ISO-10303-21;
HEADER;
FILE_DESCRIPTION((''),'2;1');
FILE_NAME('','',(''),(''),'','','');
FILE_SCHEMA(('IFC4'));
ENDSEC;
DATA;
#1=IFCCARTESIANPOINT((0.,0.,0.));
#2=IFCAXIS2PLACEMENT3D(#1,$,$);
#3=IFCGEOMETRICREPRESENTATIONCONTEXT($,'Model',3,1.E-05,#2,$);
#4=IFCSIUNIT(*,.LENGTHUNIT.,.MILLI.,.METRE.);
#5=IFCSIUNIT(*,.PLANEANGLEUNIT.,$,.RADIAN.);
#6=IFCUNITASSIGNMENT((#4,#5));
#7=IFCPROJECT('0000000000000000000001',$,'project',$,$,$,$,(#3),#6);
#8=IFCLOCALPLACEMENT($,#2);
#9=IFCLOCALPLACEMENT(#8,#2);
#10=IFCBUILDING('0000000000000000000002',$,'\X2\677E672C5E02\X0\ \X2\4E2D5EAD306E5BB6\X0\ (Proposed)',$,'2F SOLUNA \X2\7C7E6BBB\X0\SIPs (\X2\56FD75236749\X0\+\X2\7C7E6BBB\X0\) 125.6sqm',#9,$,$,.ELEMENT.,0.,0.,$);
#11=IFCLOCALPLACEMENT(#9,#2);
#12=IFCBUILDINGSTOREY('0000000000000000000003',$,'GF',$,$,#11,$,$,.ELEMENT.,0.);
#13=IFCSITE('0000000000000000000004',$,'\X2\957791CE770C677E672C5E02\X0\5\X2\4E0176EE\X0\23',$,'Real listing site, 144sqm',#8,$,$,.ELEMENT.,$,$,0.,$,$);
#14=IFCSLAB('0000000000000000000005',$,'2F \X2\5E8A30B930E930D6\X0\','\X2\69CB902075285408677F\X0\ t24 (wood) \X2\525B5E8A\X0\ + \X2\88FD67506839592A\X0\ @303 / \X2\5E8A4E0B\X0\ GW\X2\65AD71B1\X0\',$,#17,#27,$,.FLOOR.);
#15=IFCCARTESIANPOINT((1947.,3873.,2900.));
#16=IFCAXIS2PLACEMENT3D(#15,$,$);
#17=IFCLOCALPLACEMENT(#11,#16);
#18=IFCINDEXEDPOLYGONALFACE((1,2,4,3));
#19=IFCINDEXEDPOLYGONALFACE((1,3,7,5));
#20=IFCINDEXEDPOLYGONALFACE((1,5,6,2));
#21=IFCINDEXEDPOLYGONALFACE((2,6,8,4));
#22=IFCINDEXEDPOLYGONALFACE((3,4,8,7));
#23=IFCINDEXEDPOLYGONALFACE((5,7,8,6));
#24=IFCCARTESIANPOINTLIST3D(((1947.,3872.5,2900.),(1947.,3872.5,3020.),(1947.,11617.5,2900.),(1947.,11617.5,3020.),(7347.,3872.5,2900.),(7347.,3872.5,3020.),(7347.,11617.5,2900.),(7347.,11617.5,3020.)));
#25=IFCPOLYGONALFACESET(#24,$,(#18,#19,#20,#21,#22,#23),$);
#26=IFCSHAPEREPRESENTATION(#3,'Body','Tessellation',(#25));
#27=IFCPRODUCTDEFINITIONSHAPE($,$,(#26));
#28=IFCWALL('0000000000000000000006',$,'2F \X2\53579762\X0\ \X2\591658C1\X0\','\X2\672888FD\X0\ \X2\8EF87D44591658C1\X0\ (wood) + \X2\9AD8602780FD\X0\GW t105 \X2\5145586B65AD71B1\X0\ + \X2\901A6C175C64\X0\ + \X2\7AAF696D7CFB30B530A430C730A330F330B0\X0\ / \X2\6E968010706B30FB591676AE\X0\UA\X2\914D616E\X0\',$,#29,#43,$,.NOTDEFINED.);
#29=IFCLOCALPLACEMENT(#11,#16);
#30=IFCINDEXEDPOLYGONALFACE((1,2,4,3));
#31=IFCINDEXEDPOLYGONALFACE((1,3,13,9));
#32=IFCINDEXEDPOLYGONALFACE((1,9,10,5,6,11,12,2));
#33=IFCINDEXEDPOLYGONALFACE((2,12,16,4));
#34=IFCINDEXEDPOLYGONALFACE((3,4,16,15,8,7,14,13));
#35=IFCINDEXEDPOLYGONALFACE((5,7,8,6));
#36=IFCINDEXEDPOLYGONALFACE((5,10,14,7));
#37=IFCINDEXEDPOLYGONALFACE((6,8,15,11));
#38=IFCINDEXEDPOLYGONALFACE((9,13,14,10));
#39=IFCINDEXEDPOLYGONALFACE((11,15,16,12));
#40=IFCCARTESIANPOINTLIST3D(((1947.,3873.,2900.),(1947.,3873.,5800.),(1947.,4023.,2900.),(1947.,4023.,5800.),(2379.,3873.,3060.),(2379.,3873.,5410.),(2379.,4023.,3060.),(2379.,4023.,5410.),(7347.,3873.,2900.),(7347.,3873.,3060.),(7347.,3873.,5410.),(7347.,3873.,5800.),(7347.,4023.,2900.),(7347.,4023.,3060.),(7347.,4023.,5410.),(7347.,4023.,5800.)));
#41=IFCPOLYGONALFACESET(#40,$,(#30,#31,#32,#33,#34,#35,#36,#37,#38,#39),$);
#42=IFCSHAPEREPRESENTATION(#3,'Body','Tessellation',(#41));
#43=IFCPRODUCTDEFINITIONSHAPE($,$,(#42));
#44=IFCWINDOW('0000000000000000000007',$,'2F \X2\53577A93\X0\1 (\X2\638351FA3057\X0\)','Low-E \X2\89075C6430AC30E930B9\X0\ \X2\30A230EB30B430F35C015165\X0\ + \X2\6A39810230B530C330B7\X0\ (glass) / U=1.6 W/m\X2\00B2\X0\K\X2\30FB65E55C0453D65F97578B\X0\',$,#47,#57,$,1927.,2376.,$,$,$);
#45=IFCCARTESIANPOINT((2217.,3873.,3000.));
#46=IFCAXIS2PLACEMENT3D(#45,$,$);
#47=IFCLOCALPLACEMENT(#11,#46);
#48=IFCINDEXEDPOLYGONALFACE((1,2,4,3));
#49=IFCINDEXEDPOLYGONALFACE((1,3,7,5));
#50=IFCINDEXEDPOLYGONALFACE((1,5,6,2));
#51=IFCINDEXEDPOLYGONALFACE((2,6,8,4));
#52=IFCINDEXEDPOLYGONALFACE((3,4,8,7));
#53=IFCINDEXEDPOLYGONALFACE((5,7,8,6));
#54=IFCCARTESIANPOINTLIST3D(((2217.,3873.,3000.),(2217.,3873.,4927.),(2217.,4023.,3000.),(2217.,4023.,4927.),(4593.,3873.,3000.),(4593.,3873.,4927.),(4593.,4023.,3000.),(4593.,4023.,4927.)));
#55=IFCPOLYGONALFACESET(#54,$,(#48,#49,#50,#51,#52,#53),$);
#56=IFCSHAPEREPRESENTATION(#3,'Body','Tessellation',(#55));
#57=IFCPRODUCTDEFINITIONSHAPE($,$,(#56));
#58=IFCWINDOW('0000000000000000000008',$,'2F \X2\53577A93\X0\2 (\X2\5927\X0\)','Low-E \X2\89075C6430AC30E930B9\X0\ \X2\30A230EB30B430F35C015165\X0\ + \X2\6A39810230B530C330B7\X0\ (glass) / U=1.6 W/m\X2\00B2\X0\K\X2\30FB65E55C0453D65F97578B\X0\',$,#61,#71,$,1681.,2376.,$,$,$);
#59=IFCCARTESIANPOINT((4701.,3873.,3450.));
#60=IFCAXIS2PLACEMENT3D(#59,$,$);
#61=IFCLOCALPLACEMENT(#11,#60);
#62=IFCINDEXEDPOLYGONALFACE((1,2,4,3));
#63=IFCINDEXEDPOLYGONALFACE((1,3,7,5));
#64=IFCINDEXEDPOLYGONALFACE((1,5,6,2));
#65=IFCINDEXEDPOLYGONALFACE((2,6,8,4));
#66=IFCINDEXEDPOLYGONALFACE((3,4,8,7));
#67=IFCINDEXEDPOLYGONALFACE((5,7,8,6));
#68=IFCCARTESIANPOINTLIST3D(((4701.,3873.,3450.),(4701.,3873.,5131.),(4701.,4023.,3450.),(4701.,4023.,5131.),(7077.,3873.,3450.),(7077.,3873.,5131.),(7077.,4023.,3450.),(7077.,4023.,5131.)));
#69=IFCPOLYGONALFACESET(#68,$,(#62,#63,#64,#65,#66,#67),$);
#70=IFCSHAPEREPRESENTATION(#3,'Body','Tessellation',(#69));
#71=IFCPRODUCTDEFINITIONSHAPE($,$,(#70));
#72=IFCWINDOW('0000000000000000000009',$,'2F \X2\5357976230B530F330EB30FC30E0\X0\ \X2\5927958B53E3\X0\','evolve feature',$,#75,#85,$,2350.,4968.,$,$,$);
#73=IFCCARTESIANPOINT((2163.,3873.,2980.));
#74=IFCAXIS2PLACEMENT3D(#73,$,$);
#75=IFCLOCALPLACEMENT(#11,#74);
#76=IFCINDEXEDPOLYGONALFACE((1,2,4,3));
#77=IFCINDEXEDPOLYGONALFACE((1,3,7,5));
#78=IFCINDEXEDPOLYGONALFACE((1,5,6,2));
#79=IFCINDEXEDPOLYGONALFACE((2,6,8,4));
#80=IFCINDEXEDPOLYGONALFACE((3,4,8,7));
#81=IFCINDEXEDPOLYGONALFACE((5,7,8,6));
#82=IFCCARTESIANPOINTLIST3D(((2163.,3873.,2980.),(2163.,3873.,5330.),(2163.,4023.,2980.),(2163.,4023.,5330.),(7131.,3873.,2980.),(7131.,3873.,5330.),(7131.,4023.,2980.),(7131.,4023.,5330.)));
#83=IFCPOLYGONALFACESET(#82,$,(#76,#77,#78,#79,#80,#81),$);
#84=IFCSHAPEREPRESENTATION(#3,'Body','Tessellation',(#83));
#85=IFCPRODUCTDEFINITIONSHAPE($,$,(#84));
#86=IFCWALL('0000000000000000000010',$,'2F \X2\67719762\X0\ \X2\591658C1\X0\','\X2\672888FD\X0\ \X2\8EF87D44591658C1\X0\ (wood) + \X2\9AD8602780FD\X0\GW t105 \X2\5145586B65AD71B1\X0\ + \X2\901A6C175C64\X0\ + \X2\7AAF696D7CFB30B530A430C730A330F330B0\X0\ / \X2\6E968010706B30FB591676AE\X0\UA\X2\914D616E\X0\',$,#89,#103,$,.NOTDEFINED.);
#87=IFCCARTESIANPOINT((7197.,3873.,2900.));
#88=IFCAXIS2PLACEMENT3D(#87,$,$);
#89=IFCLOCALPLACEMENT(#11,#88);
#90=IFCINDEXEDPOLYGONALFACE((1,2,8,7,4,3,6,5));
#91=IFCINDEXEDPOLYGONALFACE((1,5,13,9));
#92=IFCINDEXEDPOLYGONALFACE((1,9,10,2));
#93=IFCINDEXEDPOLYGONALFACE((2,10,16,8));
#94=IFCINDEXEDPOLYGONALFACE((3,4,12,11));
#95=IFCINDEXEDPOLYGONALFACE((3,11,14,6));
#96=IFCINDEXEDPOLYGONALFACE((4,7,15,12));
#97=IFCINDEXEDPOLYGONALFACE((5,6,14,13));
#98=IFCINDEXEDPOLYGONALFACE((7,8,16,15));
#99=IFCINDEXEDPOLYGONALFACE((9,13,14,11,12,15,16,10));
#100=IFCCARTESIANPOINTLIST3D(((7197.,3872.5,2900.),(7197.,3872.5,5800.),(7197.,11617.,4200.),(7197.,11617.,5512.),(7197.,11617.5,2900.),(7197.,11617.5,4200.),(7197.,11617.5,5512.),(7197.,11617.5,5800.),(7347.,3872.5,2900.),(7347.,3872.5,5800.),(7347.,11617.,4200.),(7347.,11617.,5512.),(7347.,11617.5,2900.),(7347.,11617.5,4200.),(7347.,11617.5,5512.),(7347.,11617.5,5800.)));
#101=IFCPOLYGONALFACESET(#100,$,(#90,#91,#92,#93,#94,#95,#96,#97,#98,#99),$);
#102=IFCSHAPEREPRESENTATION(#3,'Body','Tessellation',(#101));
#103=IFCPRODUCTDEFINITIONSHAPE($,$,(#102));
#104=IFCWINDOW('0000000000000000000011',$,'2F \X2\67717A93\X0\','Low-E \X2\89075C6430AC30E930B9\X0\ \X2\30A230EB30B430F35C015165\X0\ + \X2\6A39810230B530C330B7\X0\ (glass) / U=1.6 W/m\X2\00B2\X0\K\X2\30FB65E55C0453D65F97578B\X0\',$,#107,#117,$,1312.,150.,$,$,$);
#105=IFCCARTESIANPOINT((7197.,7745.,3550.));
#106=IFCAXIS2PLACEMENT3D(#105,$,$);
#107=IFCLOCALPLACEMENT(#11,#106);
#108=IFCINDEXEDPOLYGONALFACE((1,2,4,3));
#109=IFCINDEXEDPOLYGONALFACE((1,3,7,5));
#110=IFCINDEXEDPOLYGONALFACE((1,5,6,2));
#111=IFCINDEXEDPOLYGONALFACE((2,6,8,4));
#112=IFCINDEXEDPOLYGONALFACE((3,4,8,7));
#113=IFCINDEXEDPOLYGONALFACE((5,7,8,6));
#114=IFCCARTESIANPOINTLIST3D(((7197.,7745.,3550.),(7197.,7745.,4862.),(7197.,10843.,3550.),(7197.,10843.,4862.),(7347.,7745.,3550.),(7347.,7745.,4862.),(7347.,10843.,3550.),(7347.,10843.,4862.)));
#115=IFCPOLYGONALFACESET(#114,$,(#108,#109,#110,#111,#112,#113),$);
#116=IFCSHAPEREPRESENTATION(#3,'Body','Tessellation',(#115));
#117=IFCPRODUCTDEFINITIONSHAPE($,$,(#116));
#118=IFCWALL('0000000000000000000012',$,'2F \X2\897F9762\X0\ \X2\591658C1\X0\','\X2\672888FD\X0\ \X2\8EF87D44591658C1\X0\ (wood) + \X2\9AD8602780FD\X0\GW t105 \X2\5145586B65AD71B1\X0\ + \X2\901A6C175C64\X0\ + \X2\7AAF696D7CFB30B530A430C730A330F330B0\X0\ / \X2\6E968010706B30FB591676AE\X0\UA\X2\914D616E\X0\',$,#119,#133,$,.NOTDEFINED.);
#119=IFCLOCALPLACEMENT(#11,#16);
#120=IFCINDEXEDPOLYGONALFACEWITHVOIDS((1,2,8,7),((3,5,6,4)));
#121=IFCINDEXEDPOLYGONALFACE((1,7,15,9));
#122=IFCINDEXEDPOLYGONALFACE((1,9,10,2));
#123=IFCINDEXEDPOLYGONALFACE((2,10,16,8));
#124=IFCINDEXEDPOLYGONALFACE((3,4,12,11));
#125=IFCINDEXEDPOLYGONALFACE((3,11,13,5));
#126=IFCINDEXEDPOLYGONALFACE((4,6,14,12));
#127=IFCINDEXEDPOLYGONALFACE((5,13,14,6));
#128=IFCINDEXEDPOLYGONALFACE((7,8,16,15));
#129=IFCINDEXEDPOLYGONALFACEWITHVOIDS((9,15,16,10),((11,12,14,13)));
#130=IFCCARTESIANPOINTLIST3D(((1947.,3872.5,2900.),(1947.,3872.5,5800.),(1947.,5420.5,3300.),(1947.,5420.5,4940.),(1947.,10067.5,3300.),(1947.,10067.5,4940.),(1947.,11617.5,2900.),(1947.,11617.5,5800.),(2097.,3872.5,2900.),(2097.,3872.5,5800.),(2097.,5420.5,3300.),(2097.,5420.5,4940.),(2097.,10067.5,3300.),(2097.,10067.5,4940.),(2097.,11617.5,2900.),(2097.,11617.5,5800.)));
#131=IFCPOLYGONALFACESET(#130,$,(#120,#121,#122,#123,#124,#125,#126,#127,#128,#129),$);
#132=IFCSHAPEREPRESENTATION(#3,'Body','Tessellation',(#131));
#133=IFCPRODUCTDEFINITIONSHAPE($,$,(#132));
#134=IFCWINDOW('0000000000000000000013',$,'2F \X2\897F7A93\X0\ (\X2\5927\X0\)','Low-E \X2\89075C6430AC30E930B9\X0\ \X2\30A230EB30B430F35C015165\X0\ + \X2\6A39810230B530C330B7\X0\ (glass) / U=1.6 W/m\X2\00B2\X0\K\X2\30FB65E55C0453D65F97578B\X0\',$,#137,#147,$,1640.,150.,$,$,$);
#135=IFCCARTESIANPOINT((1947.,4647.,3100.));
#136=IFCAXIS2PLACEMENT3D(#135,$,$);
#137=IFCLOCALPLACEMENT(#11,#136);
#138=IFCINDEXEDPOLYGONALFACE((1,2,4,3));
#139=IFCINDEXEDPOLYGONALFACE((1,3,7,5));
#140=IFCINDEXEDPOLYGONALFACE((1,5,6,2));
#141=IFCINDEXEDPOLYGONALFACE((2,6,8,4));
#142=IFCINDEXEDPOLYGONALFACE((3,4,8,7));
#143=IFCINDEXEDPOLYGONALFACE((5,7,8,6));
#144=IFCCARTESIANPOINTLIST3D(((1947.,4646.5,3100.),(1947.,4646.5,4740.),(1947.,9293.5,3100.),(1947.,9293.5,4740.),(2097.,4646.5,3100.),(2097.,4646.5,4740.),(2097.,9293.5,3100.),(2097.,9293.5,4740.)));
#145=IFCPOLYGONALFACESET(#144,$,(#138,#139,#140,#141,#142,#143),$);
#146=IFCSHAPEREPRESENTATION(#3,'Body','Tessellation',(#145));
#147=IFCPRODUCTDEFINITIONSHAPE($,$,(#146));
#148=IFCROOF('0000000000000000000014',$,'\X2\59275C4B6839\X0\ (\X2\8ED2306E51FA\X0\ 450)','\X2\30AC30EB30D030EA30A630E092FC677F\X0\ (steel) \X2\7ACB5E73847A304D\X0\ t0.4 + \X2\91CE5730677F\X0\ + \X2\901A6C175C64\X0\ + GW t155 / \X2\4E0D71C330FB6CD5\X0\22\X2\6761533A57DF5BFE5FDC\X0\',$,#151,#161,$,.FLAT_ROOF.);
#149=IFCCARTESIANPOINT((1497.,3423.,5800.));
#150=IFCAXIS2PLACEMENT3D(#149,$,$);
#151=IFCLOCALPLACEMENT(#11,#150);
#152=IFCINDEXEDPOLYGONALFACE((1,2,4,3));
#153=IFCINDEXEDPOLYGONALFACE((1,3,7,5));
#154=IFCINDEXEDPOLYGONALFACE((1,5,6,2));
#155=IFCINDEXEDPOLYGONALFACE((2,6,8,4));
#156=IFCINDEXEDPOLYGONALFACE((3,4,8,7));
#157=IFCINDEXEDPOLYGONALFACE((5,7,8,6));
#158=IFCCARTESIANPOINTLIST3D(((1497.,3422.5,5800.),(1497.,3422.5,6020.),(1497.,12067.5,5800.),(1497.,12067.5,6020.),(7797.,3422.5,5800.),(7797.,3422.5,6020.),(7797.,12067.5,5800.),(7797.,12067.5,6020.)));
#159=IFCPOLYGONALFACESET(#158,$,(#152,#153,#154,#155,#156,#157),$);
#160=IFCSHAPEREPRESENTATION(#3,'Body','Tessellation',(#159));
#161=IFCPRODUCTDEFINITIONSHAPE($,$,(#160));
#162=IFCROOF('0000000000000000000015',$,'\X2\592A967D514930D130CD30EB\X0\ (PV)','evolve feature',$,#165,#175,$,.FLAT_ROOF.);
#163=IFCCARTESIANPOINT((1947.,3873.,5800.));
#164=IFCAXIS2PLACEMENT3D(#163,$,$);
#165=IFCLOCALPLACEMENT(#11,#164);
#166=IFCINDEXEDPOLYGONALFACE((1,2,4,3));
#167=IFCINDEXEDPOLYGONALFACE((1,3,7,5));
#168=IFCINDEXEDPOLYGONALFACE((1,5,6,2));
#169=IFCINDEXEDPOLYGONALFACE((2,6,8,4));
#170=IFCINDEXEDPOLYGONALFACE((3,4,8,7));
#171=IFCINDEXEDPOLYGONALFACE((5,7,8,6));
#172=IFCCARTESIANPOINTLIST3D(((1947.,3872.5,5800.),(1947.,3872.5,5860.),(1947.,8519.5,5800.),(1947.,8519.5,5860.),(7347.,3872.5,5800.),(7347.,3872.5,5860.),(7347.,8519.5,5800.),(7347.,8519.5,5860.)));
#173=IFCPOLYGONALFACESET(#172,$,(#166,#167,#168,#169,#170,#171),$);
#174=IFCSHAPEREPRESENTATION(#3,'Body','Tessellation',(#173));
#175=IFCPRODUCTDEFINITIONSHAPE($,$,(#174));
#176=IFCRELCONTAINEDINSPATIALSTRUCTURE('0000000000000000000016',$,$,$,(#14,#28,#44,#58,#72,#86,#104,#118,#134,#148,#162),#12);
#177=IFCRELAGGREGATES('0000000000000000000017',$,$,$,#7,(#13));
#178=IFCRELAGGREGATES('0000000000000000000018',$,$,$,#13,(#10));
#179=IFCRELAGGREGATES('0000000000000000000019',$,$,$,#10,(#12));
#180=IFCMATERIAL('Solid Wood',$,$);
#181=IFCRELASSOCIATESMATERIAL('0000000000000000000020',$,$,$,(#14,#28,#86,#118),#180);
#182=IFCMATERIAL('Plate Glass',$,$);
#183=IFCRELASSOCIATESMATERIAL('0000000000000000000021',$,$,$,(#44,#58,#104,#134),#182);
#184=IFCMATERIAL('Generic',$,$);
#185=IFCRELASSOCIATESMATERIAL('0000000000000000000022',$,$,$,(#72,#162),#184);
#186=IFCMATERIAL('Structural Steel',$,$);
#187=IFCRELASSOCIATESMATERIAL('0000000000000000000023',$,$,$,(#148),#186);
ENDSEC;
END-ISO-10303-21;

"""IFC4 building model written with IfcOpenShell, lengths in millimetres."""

from ifc_helpers import new_model, si_unit, frame, frame_2d, origin, place, context, project, spatial, rectangle, extrude, material, element, fill, save


model = new_model("IFC4")

# Units and contexts
model_context = context("Model", 3, precision=1e-05, world=origin())
ifc_project = project(units=[si_unit("LENGTHUNIT", "METRE", prefix="MILLI"), si_unit("PLANEANGLEUNIT", "RADIAN")], contexts=[model_context])

# Site, building, storey
site_placement = place(None, origin())
site = spatial("IfcSite", under=ifc_project, at=site_placement, Name="長野県松本市5丁目23", ObjectType="Real listing site, 144sqm", CompositionType="ELEMENT", RefElevation=0.0)
building_placement = place(site_placement, origin())
building = spatial("IfcBuilding", under=site, at=building_placement, Name="松本市 中庭の家 (Proposed)", ObjectType="2F SOLUNA 籾殻SIPs (国産杉+籾殻) 125.6sqm", CompositionType="ELEMENT", ElevationOfRefHeight=0.0, ElevationOfTerrain=0.0)
storey_placement = place(building_placement, origin())
storey = spatial("IfcBuildingStorey", under=building, at=storey_placement, Name="GF", CompositionType="ELEMENT", Elevation=0.0)

# Slab
ifc_material_1 = material(Name="Solid Wood")
slab_placement = place(storey_placement, frame((1947.0, 3873.0, 2900.0)))
element("IfcSlab", 1, at=slab_placement, inside=storey, material=ifc_material_1, Name="2F 床スラブ", Description="構造用合板 t24 (wood) 剛床 + 製材根太 @303 / 床下 GW断熱", PredefinedType="FLOOR", context=model_context, shape_type="SweptSolid", body=[
    extrude(rectangle(XDim=5400.0, YDim=7745.0, at=frame_2d((2700.0, 3872.0))), frame((1947.0, 3873.0, 2900.0)), (0.0, 0.0, 1.0), 120.0),
])

# Wall, openings, windows
wall_1_placement = place(storey_placement, frame((1947.0, 3873.0, 2900.0)))
wall_1 = element("IfcWall", 2, at=wall_1_placement, inside=storey, material=ifc_material_1, Name="2F 南面 外壁", Description="木製 軸組外壁 (wood) + 高性能GW t105 充填断熱 + 通気層 + 窯業系サイディング / 準耐火・外皮UA配慮", PredefinedType="NOTDEFINED", context=model_context, shape_type="SweptSolid", body=[
    extrude(rectangle(XDim=5400.0, YDim=150.0, at=frame_2d((2700.0, 75.0))), frame((1947.0, 3873.0, 2900.0)), (0.0, 0.0, 1.0), 2900.0),
])
opening_1_placement = place(storey_placement, frame((2217.0, 3873.0, 3000.0)))
opening_1 = element("IfcOpeningElement", 3, at=opening_1_placement, cuts=wall_1, PredefinedType="NOTDEFINED", context=model_context, shape_type="SweptSolid", body=[
    extrude(rectangle(XDim=2376.0, YDim=150.0, at=frame_2d((1188.0, 75.0))), frame((2217.0, 3873.0, 3000.0)), (0.0, 0.0, 1.0), 1927.0),
])
opening_2_placement = place(storey_placement, frame((4701.0, 3873.0, 3450.0)))
opening_2 = element("IfcOpeningElement", 4, at=opening_2_placement, cuts=wall_1, PredefinedType="NOTDEFINED", context=model_context, shape_type="SweptSolid", body=[
    extrude(rectangle(XDim=2376.0, YDim=150.0, at=frame_2d((1188.0, 75.0))), frame((4701.0, 3873.0, 3450.0)), (0.0, 0.0, 1.0), 1681.0),
])
opening_3_placement = place(storey_placement, frame((2163.0, 3873.0, 2980.0)))
opening_3 = element("IfcOpeningElement", 5, at=opening_3_placement, cuts=wall_1, PredefinedType="NOTDEFINED", context=model_context, shape_type="SweptSolid", body=[
    extrude(rectangle(XDim=4968.0, YDim=150.0, at=frame_2d((2484.0, 75.0))), frame((2163.0, 3873.0, 2980.0)), (0.0, 0.0, 1.0), 2350.0),
])
ifc_material_2 = material(Name="Plate Glass")
window_1_placement = place(storey_placement, frame((2217.0, 3873.0, 3000.0)))
window_1 = element("IfcWindow", 6, at=window_1_placement, inside=storey, material=ifc_material_2, Name="2F 南窓1 (掃出し)", Description="Low-E 複層ガラス アルゴン封入 + 樹脂サッシ (glass) / U=1.6 W/m²K・日射取得型", OverallHeight=1927.0, OverallWidth=2376.0, context=model_context, shape_type="SweptSolid", body=[
    extrude(rectangle(XDim=2376.0, YDim=150.0, at=frame_2d((1188.0, 75.0))), frame((2217.0, 3873.0, 3000.0)), (0.0, 0.0, 1.0), 1927.0),
])
fill(opening_1, window_1)
window_2_placement = place(storey_placement, frame((4701.0, 3873.0, 3450.0)))
window_2 = element("IfcWindow", 7, at=window_2_placement, inside=storey, material=ifc_material_2, Name="2F 南窓2 (大)", Description="Low-E 複層ガラス アルゴン封入 + 樹脂サッシ (glass) / U=1.6 W/m²K・日射取得型", OverallHeight=1681.0, OverallWidth=2376.0, context=model_context, shape_type="SweptSolid", body=[
    extrude(rectangle(XDim=2376.0, YDim=150.0, at=frame_2d((1188.0, 75.0))), frame((4701.0, 3873.0, 3450.0)), (0.0, 0.0, 1.0), 1681.0),
])
fill(opening_2, window_2)
ifc_material_3 = material(Name="Generic")
window_3_placement = place(storey_placement, frame((2163.0, 3873.0, 2980.0)))
window_3 = element("IfcWindow", 8, at=window_3_placement, inside=storey, material=ifc_material_3, Name="2F 南面サンルーム 大開口", Description="evolve feature", OverallHeight=2350.0, OverallWidth=4968.0, context=model_context, shape_type="SweptSolid", body=[
    extrude(rectangle(XDim=4968.0, YDim=150.0, at=frame_2d((2484.0, 75.0))), frame((2163.0, 3873.0, 2980.0)), (0.0, 0.0, 1.0), 2350.0),
])
fill(opening_3, window_3)

# Walls, openings, windows
wall_2_placement = place(storey_placement, frame((7197.0, 3873.0, 2900.0)))
wall_2 = element("IfcWall", 9, at=wall_2_placement, inside=storey, material=ifc_material_1, Name="2F 東面 外壁", Description="木製 軸組外壁 (wood) + 高性能GW t105 充填断熱 + 通気層 + 窯業系サイディング / 準耐火・外皮UA配慮", PredefinedType="NOTDEFINED", context=model_context, shape_type="SweptSolid", body=[
    extrude(rectangle(XDim=150.0, YDim=7745.0, at=frame_2d((75.0, 3872.0))), frame((7197.0, 3873.0, 2900.0)), (0.0, 0.0, 1.0), 2900.0),
])
opening_4_placement = place(storey_placement, frame((7197.0, 7745.0, 3550.0)))
opening_4 = element("IfcOpeningElement", 10, at=opening_4_placement, cuts=wall_2, PredefinedType="NOTDEFINED", context=model_context, shape_type="SweptSolid", body=[
    extrude(rectangle(XDim=150.0, YDim=3098.0, at=frame_2d((75.0, 1549.0))), frame((7197.0, 7745.0, 3550.0)), (0.0, 0.0, 1.0), 1312.0),
])
window_4_placement = place(storey_placement, frame((7197.0, 7745.0, 3550.0)))
window_4 = element("IfcWindow", 11, at=window_4_placement, inside=storey, material=ifc_material_2, Name="2F 東窓", Description="Low-E 複層ガラス アルゴン封入 + 樹脂サッシ (glass) / U=1.6 W/m²K・日射取得型", OverallHeight=1312.0, OverallWidth=150.0, context=model_context, shape_type="SweptSolid", body=[
    extrude(rectangle(XDim=150.0, YDim=3098.0, at=frame_2d((75.0, 1549.0))), frame((7197.0, 7745.0, 3550.0)), (0.0, 0.0, 1.0), 1312.0),
])
fill(opening_4, window_4)
wall_3_placement = place(storey_placement, frame((1947.0, 3873.0, 2900.0)))
wall_3 = element("IfcWall", 12, at=wall_3_placement, inside=storey, material=ifc_material_1, Name="2F 西面 外壁", Description="木製 軸組外壁 (wood) + 高性能GW t105 充填断熱 + 通気層 + 窯業系サイディング / 準耐火・外皮UA配慮", PredefinedType="NOTDEFINED", context=model_context, shape_type="SweptSolid", body=[
    extrude(rectangle(XDim=150.0, YDim=7745.0, at=frame_2d((75.0, 3872.0))), frame((1947.0, 3873.0, 2900.0)), (0.0, 0.0, 1.0), 2900.0),
])
opening_5_placement = place(storey_placement, frame((1947.0, 4647.0, 3100.0)))
opening_5 = element("IfcOpeningElement", 13, at=opening_5_placement, cuts=wall_3, PredefinedType="NOTDEFINED", context=model_context, shape_type="SweptSolid", body=[
    extrude(rectangle(XDim=150.0, YDim=4647.0, at=frame_2d((75.0, 2323.0))), frame((1947.0, 4647.0, 3100.0)), (0.0, 0.0, 1.0), 1640.0),
])
window_5_placement = place(storey_placement, frame((1947.0, 4647.0, 3100.0)))
window_5 = element("IfcWindow", 14, at=window_5_placement, inside=storey, material=ifc_material_2, Name="2F 西窓 (大)", Description="Low-E 複層ガラス アルゴン封入 + 樹脂サッシ (glass) / U=1.6 W/m²K・日射取得型", OverallHeight=1640.0, OverallWidth=150.0, context=model_context, shape_type="SweptSolid", body=[
    extrude(rectangle(XDim=150.0, YDim=4647.0, at=frame_2d((75.0, 2323.0))), frame((1947.0, 4647.0, 3100.0)), (0.0, 0.0, 1.0), 1640.0),
])
fill(opening_5, window_5)

# Roofs
ifc_material_4 = material(Name="Structural Steel")
roof_1_placement = place(storey_placement, frame((1497.0, 3423.0, 5800.0)))
element("IfcRoof", 15, at=roof_1_placement, inside=storey, material=ifc_material_4, Name="大屋根 (軒の出 450)", Description="ガルバリウム鋼板 (steel) 立平葺き t0.4 + 野地板 + 通気層 + GW t155 / 不燃・法22条区域対応", PredefinedType="FLAT_ROOF", context=model_context, shape_type="SweptSolid", body=[
    extrude(rectangle(XDim=6300.0, YDim=8645.0, at=frame_2d((3150.0, 4322.0))), frame((1497.0, 3423.0, 5800.0)), (0.0, 0.0, 1.0), 220.0),
])
roof_2_placement = place(storey_placement, frame((1947.0, 3873.0, 5800.0)))
element("IfcRoof", 16, at=roof_2_placement, inside=storey, material=ifc_material_3, Name="太陽光パネル (PV)", Description="evolve feature", PredefinedType="FLAT_ROOF", context=model_context, shape_type="SweptSolid", body=[
    extrude(rectangle(XDim=5400.0, YDim=4647.0, at=frame_2d((2700.0, 2323.0))), frame((1947.0, 3873.0, 5800.0)), (0.0, 0.0, 1.0), 60.0),
])

save(model, "model.ifc")
